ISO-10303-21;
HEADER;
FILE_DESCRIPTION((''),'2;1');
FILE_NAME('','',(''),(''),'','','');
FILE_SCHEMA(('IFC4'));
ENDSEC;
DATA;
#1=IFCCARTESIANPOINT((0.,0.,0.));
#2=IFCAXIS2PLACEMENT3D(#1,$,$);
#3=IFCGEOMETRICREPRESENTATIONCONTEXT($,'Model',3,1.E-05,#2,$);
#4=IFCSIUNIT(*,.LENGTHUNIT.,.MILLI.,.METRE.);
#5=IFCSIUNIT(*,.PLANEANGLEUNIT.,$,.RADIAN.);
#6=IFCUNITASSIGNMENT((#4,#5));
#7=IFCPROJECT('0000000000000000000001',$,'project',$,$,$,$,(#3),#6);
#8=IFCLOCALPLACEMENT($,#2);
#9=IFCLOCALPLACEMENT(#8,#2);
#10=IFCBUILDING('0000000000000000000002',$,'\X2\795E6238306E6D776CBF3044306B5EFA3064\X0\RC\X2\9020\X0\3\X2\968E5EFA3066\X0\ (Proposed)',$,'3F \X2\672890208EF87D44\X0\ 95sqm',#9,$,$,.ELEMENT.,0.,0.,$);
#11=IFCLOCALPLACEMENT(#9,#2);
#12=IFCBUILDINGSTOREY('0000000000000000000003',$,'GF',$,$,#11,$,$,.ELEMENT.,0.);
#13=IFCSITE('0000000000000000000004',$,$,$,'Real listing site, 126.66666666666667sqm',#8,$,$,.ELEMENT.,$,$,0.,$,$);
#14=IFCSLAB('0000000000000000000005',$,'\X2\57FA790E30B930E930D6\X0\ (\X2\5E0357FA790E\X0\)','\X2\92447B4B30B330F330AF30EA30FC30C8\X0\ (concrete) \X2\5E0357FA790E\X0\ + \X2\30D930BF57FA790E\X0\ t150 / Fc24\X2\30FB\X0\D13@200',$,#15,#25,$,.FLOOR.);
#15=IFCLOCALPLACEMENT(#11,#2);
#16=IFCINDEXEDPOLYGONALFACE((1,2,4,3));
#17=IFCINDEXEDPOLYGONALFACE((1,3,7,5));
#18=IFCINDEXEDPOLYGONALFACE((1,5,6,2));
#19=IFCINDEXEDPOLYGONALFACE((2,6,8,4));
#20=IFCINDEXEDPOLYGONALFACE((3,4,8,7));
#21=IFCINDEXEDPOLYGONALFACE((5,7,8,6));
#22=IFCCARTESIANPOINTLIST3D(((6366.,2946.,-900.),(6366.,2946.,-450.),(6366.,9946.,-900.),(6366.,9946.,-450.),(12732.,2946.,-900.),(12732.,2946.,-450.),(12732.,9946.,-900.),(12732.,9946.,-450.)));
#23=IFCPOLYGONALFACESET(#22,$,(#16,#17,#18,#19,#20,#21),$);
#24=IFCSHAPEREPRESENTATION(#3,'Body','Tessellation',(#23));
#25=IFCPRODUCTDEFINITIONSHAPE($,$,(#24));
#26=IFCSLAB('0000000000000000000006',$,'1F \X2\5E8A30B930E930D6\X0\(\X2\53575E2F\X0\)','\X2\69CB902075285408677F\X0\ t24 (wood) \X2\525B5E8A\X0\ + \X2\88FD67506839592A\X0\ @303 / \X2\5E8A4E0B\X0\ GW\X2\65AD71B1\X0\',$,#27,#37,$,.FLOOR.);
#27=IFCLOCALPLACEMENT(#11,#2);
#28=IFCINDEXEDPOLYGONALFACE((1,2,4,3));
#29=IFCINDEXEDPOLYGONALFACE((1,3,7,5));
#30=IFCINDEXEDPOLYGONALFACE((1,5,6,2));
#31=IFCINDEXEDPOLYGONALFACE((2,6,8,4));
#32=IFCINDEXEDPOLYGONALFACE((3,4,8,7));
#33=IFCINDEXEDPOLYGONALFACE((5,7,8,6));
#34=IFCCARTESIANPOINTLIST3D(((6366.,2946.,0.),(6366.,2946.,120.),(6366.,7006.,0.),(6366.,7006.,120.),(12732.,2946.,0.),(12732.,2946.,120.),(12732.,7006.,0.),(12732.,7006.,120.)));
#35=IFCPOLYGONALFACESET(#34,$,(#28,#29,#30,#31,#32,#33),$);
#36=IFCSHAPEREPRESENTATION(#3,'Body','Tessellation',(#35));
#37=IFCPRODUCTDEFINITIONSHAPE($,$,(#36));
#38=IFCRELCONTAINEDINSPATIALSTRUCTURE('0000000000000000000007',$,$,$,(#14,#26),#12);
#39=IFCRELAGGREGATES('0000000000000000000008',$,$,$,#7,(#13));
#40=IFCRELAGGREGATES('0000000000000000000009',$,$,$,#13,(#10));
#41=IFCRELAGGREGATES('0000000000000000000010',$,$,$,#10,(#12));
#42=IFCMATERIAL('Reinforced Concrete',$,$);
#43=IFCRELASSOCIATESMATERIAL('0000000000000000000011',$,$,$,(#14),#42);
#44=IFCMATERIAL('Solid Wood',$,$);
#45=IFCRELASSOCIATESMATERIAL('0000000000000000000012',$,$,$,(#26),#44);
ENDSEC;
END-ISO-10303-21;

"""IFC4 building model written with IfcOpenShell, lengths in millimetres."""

from ifc_helpers import new_model, si_unit, frame, frame_2d, origin, place, context, project, spatial, rectangle, extrude, material, element, save


model = new_model("IFC4")

# Units and contexts
model_context = context("Model", 3, precision=1e-05, world=origin())
ifc_project = project(units=[si_unit("LENGTHUNIT", "METRE", prefix="MILLI"), si_unit("PLANEANGLEUNIT", "RADIAN")], contexts=[model_context])

# Site, building, storey
site_placement = place(None, origin())
site = spatial("IfcSite", under=ifc_project, at=site_placement, ObjectType="Real listing site, 126.66666666666667sqm", CompositionType="ELEMENT", RefElevation=0.0)
building_placement = place(site_placement, origin())
building = spatial("IfcBuilding", under=site, at=building_placement, Name="神戸の海沿いに建つRC造3階建て (Proposed)", ObjectType="3F 木造軸組 95sqm", CompositionType="ELEMENT", ElevationOfRefHeight=0.0, ElevationOfTerrain=0.0)
storey_placement = place(building_placement, origin())
storey = spatial("IfcBuildingStorey", under=building, at=storey_placement, Name="GF", CompositionType="ELEMENT", Elevation=0.0)

# Slabs
ifc_material_1 = material(Name="Reinforced Concrete")
slab_1_placement = place(storey_placement, frame((3183.0, 1473.0, -450.0)))
element("IfcSlab", 1, at=slab_1_placement, inside=storey, material=ifc_material_1, Name="基礎スラブ (布基礎)", Description="鉄筋コンクリート (concrete) 布基礎 + ベタ基礎 t150 / Fc24・D13@200", PredefinedType="FLOOR", context=model_context, shape_type="SweptSolid", body=[
    extrude(rectangle(XDim=6366.0, YDim=7000.0, at=frame_2d((3183.0, 3500.0))), frame((3183.0, 1473.0, -450.0)), (0.0, 0.0, 1.0), 450.0),
])
ifc_material_2 = material(Name="Solid Wood")
slab_2_placement = place(storey_placement, frame((3183.0, 1473.0, 0.0)))
element("IfcSlab", 2, at=slab_2_placement, inside=storey, material=ifc_material_2, Name="1F 床スラブ(南帯)", Description="構造用合板 t24 (wood) 剛床 + 製材根太 @303 / 床下 GW断熱", PredefinedType="FLOOR", context=model_context, shape_type="SweptSolid", body=[
    extrude(rectangle(XDim=6366.0, YDim=4060.0, at=frame_2d((3183.0, 2030.0))), frame((3183.0, 1473.0, 0.0)), (0.0, 0.0, 1.0), 120.0),
])

save(model, "model.ifc")
